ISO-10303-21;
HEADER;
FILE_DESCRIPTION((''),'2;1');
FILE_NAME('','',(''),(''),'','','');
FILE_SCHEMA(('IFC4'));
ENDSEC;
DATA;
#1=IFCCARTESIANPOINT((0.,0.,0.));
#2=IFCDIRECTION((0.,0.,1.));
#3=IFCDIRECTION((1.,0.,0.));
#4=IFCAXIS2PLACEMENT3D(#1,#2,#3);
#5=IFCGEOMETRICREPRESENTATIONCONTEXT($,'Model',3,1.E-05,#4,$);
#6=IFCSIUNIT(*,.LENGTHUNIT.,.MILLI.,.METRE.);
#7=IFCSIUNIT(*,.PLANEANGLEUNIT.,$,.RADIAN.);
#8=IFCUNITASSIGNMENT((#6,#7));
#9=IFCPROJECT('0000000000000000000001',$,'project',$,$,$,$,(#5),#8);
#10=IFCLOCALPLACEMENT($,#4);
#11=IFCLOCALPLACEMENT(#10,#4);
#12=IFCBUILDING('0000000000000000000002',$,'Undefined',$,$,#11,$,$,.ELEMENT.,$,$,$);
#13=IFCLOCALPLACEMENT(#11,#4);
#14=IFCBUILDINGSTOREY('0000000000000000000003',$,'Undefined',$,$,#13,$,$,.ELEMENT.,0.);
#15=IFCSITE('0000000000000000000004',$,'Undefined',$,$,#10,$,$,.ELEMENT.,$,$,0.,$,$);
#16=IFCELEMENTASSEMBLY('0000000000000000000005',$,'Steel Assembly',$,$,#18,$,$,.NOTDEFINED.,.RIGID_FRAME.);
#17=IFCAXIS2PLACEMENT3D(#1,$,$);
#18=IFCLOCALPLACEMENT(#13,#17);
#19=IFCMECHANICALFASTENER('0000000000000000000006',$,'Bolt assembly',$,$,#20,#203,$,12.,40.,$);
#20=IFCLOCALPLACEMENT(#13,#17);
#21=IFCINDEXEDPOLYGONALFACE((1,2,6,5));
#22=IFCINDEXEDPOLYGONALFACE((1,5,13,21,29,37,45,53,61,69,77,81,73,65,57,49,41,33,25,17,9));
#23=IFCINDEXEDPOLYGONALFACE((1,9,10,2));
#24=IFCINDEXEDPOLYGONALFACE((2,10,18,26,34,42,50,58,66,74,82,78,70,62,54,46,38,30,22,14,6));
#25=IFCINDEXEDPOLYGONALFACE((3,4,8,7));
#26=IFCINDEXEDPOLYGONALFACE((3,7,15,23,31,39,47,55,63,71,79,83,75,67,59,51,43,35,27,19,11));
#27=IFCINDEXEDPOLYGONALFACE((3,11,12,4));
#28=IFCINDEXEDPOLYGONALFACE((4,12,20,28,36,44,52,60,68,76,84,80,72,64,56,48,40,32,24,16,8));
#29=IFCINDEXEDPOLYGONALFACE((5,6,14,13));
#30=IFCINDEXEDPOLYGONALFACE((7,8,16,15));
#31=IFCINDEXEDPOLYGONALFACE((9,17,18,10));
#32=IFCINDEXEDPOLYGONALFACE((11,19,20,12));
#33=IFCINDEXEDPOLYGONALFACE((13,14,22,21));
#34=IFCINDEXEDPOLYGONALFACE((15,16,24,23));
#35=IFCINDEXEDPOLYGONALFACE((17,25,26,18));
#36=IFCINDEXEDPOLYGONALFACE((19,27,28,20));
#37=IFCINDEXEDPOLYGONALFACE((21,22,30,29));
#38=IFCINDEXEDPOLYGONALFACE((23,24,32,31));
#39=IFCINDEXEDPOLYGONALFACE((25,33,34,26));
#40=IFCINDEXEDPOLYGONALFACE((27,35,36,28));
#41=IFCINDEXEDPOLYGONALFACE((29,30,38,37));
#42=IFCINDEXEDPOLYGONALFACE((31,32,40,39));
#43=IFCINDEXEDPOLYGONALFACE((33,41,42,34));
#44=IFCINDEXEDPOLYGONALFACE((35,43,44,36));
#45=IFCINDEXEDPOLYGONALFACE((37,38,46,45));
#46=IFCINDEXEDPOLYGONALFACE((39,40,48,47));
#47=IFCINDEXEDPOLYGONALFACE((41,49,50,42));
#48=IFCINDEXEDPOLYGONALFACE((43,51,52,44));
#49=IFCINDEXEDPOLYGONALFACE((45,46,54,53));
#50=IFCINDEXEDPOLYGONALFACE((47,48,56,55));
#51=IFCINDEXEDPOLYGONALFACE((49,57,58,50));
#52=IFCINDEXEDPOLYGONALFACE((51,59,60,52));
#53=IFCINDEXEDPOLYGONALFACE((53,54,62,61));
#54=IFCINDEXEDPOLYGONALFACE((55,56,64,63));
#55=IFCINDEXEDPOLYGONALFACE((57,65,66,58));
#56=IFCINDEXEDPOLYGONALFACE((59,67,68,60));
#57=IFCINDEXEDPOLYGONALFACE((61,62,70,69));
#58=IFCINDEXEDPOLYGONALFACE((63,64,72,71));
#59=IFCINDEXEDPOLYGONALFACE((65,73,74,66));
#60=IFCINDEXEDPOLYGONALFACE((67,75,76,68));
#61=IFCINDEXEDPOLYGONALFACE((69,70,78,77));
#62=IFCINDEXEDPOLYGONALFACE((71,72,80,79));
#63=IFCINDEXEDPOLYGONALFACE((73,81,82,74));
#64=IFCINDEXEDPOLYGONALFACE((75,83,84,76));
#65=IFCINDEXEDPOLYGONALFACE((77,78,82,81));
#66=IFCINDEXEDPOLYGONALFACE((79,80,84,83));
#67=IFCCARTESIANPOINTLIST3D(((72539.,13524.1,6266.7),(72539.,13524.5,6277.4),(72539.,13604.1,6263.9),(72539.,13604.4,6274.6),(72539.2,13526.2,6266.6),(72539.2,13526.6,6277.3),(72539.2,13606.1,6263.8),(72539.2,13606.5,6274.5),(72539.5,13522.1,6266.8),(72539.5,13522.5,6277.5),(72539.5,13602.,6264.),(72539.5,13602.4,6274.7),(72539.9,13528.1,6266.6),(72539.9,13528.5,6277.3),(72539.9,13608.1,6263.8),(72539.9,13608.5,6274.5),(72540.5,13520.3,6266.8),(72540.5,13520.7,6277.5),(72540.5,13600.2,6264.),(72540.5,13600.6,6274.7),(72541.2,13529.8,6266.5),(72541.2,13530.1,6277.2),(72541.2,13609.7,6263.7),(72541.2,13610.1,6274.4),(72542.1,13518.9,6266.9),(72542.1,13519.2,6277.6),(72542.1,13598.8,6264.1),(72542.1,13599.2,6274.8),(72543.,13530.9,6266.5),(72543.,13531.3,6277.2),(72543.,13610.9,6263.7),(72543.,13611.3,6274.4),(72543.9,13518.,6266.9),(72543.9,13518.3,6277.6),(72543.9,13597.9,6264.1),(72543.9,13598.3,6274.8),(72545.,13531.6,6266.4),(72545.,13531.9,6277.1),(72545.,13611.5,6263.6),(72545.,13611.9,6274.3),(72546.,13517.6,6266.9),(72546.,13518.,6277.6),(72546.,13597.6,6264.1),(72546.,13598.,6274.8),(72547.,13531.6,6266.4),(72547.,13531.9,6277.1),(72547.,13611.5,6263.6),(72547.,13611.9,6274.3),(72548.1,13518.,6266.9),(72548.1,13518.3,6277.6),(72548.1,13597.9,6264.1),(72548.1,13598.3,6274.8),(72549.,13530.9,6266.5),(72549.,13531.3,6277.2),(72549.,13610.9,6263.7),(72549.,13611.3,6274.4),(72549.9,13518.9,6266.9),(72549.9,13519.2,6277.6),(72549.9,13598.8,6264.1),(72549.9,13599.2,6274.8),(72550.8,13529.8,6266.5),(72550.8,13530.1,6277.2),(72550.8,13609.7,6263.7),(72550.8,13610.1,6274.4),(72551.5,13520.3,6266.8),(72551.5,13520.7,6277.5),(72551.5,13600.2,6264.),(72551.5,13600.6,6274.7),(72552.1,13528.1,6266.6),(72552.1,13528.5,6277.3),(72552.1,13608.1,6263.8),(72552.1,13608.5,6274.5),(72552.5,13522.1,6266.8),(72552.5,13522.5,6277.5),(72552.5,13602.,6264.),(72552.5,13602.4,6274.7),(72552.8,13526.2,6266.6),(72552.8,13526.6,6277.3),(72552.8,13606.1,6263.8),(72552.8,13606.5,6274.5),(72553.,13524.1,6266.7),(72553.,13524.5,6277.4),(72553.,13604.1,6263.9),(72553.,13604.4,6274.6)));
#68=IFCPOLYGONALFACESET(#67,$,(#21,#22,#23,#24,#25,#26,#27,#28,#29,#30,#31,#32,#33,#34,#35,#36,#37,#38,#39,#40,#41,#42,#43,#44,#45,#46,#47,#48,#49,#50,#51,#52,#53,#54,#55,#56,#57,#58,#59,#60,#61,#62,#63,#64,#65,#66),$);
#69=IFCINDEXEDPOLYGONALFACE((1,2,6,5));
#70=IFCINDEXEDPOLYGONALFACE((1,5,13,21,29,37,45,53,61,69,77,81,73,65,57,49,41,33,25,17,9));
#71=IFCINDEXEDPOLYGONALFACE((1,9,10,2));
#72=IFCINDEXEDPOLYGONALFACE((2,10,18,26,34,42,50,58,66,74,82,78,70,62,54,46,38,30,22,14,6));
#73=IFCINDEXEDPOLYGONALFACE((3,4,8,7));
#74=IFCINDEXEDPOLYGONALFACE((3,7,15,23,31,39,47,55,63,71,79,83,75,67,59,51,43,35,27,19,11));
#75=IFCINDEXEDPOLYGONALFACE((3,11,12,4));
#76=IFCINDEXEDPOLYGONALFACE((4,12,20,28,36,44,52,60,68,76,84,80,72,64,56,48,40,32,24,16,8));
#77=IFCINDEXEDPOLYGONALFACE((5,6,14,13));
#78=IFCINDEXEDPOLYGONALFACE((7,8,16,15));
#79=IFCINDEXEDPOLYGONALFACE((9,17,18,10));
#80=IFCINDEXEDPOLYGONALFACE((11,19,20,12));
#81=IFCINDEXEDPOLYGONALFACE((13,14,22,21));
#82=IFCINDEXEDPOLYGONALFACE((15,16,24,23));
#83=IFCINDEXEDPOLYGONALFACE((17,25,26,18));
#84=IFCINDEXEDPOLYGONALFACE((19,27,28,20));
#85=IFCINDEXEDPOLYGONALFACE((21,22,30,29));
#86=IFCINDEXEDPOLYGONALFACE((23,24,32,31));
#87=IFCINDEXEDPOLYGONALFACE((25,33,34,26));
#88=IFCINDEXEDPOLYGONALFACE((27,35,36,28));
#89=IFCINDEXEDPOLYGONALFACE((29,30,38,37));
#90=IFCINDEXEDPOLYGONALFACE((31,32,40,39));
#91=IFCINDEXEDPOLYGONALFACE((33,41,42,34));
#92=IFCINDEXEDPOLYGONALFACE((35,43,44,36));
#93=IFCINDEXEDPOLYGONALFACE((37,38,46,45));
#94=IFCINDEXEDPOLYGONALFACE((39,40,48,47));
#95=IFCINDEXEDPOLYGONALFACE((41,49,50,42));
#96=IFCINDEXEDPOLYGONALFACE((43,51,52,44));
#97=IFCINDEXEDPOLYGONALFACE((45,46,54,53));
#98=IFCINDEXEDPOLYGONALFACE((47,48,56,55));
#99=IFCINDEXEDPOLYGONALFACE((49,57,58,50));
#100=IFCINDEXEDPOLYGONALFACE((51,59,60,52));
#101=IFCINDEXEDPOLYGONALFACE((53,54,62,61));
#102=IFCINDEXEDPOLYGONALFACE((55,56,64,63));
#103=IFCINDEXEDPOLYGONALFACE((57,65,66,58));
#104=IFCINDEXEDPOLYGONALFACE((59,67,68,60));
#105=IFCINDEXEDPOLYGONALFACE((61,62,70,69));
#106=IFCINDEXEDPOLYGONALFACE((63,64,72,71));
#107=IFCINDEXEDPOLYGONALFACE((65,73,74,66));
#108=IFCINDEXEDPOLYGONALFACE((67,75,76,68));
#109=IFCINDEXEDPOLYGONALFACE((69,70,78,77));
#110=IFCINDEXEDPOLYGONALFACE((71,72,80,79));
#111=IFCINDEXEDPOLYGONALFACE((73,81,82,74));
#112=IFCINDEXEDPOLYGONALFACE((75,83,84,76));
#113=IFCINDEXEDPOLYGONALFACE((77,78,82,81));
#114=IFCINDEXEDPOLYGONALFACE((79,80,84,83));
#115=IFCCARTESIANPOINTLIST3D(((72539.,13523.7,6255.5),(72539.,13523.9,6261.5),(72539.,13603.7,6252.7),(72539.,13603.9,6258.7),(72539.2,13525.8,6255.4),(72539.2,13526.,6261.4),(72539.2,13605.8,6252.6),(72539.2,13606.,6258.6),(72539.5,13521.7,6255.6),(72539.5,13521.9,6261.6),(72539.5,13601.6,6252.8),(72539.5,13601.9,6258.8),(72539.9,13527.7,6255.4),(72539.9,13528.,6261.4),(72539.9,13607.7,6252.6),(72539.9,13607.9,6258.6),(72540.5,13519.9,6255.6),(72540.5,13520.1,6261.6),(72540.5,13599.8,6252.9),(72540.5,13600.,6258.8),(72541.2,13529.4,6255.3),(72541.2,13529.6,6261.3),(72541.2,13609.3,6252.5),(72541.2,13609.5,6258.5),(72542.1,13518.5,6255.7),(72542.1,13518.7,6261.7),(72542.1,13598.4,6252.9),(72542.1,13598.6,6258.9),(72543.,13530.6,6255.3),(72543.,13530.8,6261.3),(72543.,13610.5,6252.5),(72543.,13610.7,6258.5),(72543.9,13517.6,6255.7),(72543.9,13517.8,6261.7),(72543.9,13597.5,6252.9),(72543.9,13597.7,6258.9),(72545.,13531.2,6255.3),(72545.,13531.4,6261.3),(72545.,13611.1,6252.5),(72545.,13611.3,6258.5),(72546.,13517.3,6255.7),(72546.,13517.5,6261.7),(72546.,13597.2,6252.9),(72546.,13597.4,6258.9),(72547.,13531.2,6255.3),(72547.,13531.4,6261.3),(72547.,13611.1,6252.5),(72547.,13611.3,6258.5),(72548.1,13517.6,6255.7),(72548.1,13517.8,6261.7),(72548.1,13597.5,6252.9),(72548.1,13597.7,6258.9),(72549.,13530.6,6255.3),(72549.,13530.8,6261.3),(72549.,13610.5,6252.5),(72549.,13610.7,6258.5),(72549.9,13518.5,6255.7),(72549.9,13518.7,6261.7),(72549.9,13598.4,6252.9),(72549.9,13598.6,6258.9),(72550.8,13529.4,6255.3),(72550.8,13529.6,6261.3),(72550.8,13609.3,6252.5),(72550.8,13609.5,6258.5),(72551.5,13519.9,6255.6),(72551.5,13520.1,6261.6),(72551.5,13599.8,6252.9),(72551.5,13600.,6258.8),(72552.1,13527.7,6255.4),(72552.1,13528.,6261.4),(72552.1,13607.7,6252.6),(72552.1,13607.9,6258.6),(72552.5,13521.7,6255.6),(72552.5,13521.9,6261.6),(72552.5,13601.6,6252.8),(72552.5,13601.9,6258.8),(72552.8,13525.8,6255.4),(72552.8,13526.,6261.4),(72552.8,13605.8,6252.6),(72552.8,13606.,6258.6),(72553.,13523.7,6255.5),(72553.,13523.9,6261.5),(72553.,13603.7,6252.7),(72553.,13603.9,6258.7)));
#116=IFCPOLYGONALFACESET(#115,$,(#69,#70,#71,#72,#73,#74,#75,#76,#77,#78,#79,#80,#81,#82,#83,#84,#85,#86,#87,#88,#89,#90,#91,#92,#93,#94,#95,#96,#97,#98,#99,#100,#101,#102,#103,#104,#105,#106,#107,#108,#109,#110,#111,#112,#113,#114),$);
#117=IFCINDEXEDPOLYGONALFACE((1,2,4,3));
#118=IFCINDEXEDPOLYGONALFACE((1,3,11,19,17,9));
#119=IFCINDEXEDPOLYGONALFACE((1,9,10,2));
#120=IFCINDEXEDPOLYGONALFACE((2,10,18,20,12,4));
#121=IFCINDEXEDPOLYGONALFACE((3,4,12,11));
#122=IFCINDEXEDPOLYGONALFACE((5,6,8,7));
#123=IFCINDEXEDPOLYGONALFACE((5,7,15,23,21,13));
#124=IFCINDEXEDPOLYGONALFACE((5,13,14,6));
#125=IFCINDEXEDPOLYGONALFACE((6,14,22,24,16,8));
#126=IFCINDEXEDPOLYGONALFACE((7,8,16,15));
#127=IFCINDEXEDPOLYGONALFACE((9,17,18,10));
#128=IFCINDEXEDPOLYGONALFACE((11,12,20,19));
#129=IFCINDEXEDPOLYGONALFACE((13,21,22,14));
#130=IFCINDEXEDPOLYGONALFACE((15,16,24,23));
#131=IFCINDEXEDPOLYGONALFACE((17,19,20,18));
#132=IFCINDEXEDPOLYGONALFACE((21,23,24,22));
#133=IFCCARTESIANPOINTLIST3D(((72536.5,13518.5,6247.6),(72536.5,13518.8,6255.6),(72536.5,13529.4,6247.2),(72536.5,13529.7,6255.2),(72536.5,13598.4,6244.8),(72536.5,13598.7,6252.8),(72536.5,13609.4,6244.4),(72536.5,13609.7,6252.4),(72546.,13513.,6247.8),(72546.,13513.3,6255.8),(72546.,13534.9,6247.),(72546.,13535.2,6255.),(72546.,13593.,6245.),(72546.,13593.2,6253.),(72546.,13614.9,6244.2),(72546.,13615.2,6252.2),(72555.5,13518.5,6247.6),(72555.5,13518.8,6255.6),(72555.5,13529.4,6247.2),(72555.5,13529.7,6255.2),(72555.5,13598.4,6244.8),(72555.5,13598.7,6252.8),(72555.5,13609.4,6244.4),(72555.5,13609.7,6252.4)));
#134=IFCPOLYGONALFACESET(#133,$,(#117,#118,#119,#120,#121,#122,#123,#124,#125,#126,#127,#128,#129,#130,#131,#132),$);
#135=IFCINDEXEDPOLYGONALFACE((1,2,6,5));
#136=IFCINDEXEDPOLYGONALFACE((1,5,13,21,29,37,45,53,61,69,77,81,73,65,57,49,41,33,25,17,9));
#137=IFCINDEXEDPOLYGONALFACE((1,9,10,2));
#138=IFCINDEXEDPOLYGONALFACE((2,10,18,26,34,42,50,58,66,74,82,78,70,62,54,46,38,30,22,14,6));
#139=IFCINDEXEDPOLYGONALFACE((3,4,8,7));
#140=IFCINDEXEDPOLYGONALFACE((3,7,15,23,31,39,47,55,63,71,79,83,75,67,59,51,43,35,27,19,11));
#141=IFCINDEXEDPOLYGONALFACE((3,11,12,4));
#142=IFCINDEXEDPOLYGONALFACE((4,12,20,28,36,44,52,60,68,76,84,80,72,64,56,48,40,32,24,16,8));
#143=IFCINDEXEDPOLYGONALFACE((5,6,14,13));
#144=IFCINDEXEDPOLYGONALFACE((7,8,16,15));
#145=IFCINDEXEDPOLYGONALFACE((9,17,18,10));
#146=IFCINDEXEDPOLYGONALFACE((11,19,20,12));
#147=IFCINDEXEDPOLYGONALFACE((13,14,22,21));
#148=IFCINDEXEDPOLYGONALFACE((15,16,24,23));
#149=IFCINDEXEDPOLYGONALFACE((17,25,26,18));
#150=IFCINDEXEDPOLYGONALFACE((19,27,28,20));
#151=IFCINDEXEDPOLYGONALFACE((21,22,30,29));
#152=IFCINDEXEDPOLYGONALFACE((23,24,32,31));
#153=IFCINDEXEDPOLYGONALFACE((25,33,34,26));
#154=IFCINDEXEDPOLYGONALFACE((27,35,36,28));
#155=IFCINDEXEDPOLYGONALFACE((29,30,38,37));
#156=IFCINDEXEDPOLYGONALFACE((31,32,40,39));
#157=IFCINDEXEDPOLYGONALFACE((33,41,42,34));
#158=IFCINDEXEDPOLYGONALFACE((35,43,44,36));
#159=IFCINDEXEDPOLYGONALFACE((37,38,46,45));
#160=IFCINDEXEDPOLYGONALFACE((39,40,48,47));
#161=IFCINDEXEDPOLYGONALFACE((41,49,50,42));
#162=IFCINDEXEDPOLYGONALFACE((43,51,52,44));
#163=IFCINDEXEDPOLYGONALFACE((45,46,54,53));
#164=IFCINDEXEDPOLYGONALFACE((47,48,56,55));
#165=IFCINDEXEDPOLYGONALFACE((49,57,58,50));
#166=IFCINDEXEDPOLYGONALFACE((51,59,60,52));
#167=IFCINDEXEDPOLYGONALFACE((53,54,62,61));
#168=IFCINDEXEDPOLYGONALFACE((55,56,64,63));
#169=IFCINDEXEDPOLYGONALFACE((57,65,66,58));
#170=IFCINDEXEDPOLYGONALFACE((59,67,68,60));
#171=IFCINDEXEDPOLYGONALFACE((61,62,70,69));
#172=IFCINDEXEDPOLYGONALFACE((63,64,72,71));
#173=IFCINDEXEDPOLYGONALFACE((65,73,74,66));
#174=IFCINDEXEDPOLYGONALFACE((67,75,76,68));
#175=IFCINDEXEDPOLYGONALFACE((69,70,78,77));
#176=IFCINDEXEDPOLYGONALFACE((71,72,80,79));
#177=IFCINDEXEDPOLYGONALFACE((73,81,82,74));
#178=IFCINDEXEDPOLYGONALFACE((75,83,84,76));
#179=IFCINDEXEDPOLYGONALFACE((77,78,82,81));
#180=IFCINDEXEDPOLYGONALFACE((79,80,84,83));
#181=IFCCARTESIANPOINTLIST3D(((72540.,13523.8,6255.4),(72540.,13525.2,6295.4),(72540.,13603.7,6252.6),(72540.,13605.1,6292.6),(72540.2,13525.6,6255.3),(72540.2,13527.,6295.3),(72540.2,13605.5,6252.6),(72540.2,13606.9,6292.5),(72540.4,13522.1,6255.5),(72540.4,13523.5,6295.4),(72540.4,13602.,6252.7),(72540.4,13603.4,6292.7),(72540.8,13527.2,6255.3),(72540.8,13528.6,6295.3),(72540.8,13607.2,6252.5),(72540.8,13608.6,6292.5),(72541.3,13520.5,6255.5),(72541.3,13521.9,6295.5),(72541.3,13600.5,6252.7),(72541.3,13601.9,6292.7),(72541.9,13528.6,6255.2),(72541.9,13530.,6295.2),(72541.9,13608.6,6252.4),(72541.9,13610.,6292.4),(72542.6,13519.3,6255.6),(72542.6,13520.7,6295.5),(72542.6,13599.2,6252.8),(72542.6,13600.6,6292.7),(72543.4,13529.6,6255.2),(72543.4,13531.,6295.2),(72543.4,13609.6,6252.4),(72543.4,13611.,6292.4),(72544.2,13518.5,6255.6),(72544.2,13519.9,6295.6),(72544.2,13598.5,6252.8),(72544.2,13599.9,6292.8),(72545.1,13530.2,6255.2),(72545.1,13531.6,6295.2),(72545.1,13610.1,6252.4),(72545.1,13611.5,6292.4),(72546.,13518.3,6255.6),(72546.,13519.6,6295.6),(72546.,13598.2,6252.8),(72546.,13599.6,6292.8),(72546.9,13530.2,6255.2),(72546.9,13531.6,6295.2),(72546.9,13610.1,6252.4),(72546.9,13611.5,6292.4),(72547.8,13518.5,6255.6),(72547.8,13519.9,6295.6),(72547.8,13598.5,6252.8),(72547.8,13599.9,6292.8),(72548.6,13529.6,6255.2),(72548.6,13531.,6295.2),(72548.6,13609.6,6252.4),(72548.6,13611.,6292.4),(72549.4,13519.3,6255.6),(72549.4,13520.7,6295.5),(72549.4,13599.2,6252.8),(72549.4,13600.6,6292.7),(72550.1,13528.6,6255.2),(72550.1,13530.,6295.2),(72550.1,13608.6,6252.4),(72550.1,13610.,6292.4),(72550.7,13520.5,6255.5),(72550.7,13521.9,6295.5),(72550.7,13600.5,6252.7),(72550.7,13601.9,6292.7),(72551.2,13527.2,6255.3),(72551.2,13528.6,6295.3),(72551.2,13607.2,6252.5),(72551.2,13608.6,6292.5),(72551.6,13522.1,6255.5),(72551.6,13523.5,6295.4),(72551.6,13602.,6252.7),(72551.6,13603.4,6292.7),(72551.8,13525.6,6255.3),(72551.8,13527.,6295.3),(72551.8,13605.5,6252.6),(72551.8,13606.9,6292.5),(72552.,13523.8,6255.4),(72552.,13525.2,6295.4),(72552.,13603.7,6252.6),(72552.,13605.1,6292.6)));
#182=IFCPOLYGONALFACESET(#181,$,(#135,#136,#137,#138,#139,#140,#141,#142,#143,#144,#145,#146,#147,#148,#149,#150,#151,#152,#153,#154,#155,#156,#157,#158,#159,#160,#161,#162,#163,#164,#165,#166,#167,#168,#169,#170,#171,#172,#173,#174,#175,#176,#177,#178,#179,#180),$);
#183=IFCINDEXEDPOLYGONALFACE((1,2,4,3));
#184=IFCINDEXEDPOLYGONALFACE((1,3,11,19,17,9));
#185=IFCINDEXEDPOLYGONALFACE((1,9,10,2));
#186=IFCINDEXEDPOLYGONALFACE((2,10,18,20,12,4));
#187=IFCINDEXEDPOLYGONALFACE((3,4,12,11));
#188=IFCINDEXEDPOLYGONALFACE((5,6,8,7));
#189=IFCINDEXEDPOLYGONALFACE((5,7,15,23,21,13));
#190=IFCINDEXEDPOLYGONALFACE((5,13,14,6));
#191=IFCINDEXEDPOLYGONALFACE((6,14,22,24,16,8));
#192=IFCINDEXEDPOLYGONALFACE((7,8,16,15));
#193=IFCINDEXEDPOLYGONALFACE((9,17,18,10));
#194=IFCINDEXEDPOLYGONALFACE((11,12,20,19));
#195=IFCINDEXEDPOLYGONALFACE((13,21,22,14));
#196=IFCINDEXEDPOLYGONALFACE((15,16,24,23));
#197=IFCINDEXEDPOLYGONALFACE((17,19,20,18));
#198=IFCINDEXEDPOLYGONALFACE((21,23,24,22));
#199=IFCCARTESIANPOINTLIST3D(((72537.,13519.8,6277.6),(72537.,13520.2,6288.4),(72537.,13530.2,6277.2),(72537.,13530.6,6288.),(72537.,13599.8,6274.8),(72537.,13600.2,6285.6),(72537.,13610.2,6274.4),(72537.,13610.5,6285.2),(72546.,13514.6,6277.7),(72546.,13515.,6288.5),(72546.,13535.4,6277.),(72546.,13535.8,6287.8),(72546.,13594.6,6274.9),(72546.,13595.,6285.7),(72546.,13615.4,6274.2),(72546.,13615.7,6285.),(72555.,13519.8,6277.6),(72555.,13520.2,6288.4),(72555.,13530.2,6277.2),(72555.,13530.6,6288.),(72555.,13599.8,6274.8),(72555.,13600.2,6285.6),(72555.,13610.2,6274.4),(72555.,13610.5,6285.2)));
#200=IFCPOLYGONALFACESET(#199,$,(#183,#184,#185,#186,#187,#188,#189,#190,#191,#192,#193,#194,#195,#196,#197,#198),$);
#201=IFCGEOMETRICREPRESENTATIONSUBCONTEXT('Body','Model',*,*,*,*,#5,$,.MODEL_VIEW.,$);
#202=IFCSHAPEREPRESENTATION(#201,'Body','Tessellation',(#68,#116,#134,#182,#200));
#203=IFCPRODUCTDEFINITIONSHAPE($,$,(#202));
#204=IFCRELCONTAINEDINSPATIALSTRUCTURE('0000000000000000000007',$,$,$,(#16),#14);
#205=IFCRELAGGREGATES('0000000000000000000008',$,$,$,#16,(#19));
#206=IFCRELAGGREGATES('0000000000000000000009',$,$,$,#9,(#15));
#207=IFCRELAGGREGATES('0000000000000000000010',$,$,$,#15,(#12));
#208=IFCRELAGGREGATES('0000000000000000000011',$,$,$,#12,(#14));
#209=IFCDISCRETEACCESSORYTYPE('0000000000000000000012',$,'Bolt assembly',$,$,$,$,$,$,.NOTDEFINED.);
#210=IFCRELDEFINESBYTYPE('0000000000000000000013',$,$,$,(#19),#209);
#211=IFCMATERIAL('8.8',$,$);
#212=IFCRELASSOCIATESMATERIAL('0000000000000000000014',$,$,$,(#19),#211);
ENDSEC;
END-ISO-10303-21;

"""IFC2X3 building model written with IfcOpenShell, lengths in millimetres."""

from ifc_helpers import new_model, si_unit, frame, origin_with_axes, origin_2d_with_axis, place, context, subcontext, project, spatial, polyline, circle, outline, extrude, source, transform, mapped, material, type_object, element, aggregate, save


model = new_model("IFC2X3")

# Units and contexts
model_context = context("Model", 3, precision=1e-05, world=origin_with_axes())
body_context = subcontext(model_context, "Body", "Model", "MODEL_VIEW")
ifc_project = project(units=[si_unit("LENGTHUNIT", "METRE", prefix="MILLI"), si_unit("PLANEANGLEUNIT", "RADIAN")], contexts=[model_context])

# Site, building, storey
site_placement = place(None, origin_with_axes())
site = spatial("IfcSite", under=ifc_project, at=site_placement, Name="Undefined", CompositionType="ELEMENT", RefElevation=0.0)
building_placement = place(site_placement, origin_with_axes())
building = spatial("IfcBuilding", under=site, at=building_placement, Name="Undefined", CompositionType="ELEMENT")
storey_placement = place(building_placement, origin_with_axes())
storey = spatial("IfcBuildingStorey", under=building, at=storey_placement, Name="Undefined", CompositionType="ELEMENT", Elevation=0.0)

# Element assembly
assembly_1_placement = place(storey_placement, origin_with_axes())
assembly_1 = element("IfcElementAssembly", 1, at=assembly_1_placement, inside=storey, Name="Steel Assembly", AssemblyPlace="NOTDEFINED", PredefinedType="RIGID_FRAME")

# Shared definitions
discrete_accessory_type_1 = type_object("IfcDiscreteAccessoryType", Name="Bolt assembly")
ifc_material_1 = material(Name="8.8")

# Mechanical fastener
shared_shape_1 = source(origin_with_axes(), body_context, "Body", "SweptSolid", [
    extrude(circle(Radius=7.0, at=origin_2d_with_axis()), frame((0.0, 8.3, 0.0), z_axis=(0.0, 1.0, 0.0), x_axis=(1.0, 0.0, 0.0)), (0.0, 0.0, 1.0), 10.7),
    extrude(circle(Radius=7.0, at=origin_2d_with_axis()), frame((0.0, -2.9, 0.0), z_axis=(0.0, 1.0, 0.0), x_axis=(1.0, 0.0, 0.0)), (0.0, 0.0, 1.0), 6.0),
    extrude(outline(polyline([(11.0, 0.0), (5.5, 9.5), (-5.5, 9.5), (-11.0, 0.0), (-5.5, -9.5), (5.5, -9.5), (11.0, 0.0)])), frame((0.0, -11.0, 0.0), z_axis=(0.0, 1.0, 0.0), x_axis=(1.0, 0.0, 0.0)), (0.0, 0.0, 1.0), 8.0),
    extrude(circle(Radius=6.0, at=origin_2d_with_axis()), frame((0.0, -3.0, 0.0), z_axis=(0.0, 1.0, 0.0), x_axis=(1.0, 0.0, 0.0)), (0.0, 0.0, 1.0), 40.0),
    extrude(outline(polyline([(10.4, 0.0), (5.2, 9.0), (-5.2, 9.0), (-10.4, 0.0), (-5.2, -9.0), (5.2, -9.0), (10.4, 0.0)])), frame((0.0, 19.0, 0.0), z_axis=(0.0, 1.0, 0.0), x_axis=(1.0, 0.0, 0.0)), (0.0, 0.0, 1.0), 10.8),
])
mechanical_fastener_1_placement = place(assembly_1_placement, frame((72546.0, 13604.3, 6255.6), z_axis=(-1.0, 0.0, 0.0), x_axis=(0.0, -0.999388, 0.034979)))
mechanical_fastener_1 = element("IfcMechanicalFastener", 2, at=mechanical_fastener_1_placement, type_object=discrete_accessory_type_1, material=ifc_material_1, Name="Bolt assembly", NominalDiameter=12.0, NominalLength=40.0, context=body_context, shape_type="MappedRepresentation", body=[
    mapped(shared_shape_1, transform((0.0, 0.0, 0.0))),
    mapped(shared_shape_1, transform((80.0, 0.0, 0.0))),
])
aggregate(assembly_1, [mechanical_fastener_1])

save(model, "model.ifc")
